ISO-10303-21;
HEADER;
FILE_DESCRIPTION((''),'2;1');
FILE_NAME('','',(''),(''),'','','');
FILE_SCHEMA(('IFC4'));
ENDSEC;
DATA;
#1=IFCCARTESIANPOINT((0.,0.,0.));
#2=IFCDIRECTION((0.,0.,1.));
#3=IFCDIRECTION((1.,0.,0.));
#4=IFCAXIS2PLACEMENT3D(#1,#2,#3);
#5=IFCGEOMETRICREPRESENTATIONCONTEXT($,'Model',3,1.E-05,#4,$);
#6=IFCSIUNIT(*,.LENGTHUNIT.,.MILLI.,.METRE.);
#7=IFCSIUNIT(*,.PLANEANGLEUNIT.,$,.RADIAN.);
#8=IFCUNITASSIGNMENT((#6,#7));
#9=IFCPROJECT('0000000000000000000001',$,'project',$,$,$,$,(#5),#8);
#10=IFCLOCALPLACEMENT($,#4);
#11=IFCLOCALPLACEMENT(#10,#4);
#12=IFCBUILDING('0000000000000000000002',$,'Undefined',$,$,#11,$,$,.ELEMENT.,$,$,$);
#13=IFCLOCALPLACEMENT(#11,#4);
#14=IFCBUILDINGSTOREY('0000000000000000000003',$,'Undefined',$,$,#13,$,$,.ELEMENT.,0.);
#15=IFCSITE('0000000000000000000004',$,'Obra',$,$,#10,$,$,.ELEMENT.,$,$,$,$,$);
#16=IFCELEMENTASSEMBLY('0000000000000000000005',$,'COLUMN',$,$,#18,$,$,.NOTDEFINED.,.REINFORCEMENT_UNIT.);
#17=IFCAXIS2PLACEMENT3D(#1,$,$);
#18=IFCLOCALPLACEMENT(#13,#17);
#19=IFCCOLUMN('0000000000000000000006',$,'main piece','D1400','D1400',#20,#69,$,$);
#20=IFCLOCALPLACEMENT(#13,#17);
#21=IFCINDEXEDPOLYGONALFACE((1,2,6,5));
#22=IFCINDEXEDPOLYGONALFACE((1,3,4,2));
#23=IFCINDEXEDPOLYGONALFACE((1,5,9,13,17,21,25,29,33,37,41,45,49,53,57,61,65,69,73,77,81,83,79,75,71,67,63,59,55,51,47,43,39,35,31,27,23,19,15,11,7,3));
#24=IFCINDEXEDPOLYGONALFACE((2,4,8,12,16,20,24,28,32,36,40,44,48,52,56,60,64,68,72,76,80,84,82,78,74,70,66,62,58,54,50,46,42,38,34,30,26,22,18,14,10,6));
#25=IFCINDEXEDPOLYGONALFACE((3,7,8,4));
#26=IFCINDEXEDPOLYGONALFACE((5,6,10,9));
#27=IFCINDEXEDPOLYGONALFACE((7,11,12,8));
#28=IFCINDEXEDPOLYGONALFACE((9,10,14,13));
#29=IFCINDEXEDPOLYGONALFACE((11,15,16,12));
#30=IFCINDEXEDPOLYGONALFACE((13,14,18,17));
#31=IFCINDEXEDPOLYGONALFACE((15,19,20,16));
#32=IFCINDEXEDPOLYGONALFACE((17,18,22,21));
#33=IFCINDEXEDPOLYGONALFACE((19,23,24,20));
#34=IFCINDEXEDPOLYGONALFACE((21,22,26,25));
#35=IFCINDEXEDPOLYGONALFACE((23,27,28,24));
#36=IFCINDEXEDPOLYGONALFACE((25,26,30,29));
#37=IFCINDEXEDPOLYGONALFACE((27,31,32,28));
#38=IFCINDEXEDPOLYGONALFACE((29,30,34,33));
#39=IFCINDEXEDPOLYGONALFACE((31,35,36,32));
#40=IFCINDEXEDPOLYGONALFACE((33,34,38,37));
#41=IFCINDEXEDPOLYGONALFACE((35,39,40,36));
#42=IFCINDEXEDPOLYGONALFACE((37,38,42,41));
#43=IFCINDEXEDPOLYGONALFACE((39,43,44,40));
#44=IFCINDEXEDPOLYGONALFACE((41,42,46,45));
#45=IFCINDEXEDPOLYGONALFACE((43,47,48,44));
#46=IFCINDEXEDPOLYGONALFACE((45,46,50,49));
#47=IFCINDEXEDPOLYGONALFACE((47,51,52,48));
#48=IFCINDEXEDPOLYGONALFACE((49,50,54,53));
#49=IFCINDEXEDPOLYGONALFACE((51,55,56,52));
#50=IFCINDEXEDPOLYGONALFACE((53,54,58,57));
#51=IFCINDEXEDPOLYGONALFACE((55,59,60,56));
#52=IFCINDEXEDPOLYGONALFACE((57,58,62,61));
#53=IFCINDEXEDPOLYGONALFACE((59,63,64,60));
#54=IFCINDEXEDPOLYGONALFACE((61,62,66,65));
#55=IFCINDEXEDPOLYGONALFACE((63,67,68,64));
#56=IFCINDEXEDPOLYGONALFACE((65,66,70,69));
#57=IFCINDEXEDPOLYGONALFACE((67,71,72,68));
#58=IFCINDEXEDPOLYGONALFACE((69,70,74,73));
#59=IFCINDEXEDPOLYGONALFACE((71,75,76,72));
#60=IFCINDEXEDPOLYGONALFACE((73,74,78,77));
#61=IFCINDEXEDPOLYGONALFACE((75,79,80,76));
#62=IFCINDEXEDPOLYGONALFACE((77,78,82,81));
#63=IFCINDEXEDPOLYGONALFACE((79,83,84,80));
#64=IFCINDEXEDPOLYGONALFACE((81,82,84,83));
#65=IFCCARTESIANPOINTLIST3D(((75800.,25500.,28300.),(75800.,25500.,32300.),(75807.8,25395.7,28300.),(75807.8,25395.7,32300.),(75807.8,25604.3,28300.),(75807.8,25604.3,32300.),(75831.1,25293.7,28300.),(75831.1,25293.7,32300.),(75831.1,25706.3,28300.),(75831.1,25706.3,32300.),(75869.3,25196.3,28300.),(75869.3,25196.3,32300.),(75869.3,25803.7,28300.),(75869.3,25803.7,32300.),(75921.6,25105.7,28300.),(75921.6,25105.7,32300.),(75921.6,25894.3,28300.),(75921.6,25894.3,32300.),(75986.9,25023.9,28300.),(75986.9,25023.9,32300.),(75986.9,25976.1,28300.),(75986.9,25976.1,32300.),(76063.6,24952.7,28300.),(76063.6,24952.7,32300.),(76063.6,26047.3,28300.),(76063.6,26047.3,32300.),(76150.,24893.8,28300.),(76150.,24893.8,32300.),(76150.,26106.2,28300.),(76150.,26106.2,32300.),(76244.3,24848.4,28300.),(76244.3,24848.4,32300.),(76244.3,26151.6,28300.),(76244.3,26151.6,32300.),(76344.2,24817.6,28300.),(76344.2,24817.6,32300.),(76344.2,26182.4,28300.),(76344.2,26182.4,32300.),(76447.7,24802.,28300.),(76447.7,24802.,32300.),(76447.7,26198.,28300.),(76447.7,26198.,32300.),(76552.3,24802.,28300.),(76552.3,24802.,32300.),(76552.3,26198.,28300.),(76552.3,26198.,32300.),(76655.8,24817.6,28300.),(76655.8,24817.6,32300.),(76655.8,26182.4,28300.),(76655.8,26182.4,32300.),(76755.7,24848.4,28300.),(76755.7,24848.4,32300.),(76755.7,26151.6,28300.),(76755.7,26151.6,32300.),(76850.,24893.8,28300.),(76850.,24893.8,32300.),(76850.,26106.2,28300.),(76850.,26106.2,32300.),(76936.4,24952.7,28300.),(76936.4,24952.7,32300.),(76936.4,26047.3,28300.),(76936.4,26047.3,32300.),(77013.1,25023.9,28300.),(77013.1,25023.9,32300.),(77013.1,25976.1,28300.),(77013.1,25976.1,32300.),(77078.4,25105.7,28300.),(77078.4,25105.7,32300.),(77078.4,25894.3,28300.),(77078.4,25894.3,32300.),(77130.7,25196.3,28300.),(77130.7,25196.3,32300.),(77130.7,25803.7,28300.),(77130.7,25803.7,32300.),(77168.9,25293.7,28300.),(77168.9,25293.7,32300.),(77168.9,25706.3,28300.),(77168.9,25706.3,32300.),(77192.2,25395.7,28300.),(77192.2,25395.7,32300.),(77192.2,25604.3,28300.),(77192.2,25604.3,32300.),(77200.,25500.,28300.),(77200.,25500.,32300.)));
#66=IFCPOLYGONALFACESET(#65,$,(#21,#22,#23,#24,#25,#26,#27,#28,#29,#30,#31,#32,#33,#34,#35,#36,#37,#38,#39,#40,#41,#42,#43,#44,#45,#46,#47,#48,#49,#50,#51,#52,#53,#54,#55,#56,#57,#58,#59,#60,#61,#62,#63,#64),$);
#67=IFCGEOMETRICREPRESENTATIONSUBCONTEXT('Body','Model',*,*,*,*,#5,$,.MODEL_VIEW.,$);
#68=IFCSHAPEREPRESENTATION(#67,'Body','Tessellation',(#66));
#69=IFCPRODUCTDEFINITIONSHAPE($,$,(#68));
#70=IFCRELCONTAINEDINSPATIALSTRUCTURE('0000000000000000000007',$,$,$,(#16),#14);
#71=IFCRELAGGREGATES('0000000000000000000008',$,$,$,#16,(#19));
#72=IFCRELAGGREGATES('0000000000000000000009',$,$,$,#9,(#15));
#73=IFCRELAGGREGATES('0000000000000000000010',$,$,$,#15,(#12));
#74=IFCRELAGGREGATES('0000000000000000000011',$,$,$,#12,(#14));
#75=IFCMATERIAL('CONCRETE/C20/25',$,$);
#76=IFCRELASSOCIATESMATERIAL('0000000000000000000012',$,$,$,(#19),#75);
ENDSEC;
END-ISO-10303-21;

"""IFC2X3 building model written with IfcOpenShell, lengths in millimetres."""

from ifc_helpers import new_model, si_unit, frame, origin_with_axes, origin_2d_with_axis, place, context, subcontext, project, spatial, circle, extrude, material, element, aggregate, save


model = new_model("IFC2X3")

# Units and contexts
model_context = context("Model", 3, precision=1e-05, world=origin_with_axes())
body_context = subcontext(model_context, "Body", "Model", "MODEL_VIEW")
ifc_project = project(units=[si_unit("LENGTHUNIT", "METRE", prefix="MILLI"), si_unit("PLANEANGLEUNIT", "RADIAN")], contexts=[model_context])

# Site, building, storey
site_placement = place(None, origin_with_axes())
site = spatial("IfcSite", under=ifc_project, at=site_placement, Name="Obra", CompositionType="ELEMENT")
building_placement = place(site_placement, origin_with_axes())
building = spatial("IfcBuilding", under=site, at=building_placement, Name="Undefined", CompositionType="ELEMENT")
storey_placement = place(building_placement, origin_with_axes())
storey = spatial("IfcBuildingStorey", under=building, at=storey_placement, Name="Undefined", CompositionType="ELEMENT", Elevation=0.0)

# Element assembly, column
assembly_1_placement = place(storey_placement, origin_with_axes())
assembly_1 = element("IfcElementAssembly", 1, at=assembly_1_placement, inside=storey, Name="COLUMN", AssemblyPlace="NOTDEFINED", PredefinedType="REINFORCEMENT_UNIT")
ifc_material_1 = material(Name="CONCRETE/C20/25")
column_placement = place(assembly_1_placement, frame((76500.0, 25500.0, 28300.0), z_axis=(0.0, 0.0, 1.0), x_axis=(0.0, 1.0, 0.0)))
column = element("IfcColumn", 2, at=column_placement, material=ifc_material_1, Name="main piece", Description="D1400", ObjectType="D1400", context=body_context, shape_type="SweptSolid", body=[
    extrude(circle(Radius=700.0, at=origin_2d_with_axis()), frame((0.0, 0.0, 4000.0), z_axis=(0.0, 0.0, -1.0), x_axis=(0.0, 1.0, 0.0)), (0.0, 0.0, 1.0), 4000.0),
])
aggregate(assembly_1, [column])

save(model, "model.ifc")
